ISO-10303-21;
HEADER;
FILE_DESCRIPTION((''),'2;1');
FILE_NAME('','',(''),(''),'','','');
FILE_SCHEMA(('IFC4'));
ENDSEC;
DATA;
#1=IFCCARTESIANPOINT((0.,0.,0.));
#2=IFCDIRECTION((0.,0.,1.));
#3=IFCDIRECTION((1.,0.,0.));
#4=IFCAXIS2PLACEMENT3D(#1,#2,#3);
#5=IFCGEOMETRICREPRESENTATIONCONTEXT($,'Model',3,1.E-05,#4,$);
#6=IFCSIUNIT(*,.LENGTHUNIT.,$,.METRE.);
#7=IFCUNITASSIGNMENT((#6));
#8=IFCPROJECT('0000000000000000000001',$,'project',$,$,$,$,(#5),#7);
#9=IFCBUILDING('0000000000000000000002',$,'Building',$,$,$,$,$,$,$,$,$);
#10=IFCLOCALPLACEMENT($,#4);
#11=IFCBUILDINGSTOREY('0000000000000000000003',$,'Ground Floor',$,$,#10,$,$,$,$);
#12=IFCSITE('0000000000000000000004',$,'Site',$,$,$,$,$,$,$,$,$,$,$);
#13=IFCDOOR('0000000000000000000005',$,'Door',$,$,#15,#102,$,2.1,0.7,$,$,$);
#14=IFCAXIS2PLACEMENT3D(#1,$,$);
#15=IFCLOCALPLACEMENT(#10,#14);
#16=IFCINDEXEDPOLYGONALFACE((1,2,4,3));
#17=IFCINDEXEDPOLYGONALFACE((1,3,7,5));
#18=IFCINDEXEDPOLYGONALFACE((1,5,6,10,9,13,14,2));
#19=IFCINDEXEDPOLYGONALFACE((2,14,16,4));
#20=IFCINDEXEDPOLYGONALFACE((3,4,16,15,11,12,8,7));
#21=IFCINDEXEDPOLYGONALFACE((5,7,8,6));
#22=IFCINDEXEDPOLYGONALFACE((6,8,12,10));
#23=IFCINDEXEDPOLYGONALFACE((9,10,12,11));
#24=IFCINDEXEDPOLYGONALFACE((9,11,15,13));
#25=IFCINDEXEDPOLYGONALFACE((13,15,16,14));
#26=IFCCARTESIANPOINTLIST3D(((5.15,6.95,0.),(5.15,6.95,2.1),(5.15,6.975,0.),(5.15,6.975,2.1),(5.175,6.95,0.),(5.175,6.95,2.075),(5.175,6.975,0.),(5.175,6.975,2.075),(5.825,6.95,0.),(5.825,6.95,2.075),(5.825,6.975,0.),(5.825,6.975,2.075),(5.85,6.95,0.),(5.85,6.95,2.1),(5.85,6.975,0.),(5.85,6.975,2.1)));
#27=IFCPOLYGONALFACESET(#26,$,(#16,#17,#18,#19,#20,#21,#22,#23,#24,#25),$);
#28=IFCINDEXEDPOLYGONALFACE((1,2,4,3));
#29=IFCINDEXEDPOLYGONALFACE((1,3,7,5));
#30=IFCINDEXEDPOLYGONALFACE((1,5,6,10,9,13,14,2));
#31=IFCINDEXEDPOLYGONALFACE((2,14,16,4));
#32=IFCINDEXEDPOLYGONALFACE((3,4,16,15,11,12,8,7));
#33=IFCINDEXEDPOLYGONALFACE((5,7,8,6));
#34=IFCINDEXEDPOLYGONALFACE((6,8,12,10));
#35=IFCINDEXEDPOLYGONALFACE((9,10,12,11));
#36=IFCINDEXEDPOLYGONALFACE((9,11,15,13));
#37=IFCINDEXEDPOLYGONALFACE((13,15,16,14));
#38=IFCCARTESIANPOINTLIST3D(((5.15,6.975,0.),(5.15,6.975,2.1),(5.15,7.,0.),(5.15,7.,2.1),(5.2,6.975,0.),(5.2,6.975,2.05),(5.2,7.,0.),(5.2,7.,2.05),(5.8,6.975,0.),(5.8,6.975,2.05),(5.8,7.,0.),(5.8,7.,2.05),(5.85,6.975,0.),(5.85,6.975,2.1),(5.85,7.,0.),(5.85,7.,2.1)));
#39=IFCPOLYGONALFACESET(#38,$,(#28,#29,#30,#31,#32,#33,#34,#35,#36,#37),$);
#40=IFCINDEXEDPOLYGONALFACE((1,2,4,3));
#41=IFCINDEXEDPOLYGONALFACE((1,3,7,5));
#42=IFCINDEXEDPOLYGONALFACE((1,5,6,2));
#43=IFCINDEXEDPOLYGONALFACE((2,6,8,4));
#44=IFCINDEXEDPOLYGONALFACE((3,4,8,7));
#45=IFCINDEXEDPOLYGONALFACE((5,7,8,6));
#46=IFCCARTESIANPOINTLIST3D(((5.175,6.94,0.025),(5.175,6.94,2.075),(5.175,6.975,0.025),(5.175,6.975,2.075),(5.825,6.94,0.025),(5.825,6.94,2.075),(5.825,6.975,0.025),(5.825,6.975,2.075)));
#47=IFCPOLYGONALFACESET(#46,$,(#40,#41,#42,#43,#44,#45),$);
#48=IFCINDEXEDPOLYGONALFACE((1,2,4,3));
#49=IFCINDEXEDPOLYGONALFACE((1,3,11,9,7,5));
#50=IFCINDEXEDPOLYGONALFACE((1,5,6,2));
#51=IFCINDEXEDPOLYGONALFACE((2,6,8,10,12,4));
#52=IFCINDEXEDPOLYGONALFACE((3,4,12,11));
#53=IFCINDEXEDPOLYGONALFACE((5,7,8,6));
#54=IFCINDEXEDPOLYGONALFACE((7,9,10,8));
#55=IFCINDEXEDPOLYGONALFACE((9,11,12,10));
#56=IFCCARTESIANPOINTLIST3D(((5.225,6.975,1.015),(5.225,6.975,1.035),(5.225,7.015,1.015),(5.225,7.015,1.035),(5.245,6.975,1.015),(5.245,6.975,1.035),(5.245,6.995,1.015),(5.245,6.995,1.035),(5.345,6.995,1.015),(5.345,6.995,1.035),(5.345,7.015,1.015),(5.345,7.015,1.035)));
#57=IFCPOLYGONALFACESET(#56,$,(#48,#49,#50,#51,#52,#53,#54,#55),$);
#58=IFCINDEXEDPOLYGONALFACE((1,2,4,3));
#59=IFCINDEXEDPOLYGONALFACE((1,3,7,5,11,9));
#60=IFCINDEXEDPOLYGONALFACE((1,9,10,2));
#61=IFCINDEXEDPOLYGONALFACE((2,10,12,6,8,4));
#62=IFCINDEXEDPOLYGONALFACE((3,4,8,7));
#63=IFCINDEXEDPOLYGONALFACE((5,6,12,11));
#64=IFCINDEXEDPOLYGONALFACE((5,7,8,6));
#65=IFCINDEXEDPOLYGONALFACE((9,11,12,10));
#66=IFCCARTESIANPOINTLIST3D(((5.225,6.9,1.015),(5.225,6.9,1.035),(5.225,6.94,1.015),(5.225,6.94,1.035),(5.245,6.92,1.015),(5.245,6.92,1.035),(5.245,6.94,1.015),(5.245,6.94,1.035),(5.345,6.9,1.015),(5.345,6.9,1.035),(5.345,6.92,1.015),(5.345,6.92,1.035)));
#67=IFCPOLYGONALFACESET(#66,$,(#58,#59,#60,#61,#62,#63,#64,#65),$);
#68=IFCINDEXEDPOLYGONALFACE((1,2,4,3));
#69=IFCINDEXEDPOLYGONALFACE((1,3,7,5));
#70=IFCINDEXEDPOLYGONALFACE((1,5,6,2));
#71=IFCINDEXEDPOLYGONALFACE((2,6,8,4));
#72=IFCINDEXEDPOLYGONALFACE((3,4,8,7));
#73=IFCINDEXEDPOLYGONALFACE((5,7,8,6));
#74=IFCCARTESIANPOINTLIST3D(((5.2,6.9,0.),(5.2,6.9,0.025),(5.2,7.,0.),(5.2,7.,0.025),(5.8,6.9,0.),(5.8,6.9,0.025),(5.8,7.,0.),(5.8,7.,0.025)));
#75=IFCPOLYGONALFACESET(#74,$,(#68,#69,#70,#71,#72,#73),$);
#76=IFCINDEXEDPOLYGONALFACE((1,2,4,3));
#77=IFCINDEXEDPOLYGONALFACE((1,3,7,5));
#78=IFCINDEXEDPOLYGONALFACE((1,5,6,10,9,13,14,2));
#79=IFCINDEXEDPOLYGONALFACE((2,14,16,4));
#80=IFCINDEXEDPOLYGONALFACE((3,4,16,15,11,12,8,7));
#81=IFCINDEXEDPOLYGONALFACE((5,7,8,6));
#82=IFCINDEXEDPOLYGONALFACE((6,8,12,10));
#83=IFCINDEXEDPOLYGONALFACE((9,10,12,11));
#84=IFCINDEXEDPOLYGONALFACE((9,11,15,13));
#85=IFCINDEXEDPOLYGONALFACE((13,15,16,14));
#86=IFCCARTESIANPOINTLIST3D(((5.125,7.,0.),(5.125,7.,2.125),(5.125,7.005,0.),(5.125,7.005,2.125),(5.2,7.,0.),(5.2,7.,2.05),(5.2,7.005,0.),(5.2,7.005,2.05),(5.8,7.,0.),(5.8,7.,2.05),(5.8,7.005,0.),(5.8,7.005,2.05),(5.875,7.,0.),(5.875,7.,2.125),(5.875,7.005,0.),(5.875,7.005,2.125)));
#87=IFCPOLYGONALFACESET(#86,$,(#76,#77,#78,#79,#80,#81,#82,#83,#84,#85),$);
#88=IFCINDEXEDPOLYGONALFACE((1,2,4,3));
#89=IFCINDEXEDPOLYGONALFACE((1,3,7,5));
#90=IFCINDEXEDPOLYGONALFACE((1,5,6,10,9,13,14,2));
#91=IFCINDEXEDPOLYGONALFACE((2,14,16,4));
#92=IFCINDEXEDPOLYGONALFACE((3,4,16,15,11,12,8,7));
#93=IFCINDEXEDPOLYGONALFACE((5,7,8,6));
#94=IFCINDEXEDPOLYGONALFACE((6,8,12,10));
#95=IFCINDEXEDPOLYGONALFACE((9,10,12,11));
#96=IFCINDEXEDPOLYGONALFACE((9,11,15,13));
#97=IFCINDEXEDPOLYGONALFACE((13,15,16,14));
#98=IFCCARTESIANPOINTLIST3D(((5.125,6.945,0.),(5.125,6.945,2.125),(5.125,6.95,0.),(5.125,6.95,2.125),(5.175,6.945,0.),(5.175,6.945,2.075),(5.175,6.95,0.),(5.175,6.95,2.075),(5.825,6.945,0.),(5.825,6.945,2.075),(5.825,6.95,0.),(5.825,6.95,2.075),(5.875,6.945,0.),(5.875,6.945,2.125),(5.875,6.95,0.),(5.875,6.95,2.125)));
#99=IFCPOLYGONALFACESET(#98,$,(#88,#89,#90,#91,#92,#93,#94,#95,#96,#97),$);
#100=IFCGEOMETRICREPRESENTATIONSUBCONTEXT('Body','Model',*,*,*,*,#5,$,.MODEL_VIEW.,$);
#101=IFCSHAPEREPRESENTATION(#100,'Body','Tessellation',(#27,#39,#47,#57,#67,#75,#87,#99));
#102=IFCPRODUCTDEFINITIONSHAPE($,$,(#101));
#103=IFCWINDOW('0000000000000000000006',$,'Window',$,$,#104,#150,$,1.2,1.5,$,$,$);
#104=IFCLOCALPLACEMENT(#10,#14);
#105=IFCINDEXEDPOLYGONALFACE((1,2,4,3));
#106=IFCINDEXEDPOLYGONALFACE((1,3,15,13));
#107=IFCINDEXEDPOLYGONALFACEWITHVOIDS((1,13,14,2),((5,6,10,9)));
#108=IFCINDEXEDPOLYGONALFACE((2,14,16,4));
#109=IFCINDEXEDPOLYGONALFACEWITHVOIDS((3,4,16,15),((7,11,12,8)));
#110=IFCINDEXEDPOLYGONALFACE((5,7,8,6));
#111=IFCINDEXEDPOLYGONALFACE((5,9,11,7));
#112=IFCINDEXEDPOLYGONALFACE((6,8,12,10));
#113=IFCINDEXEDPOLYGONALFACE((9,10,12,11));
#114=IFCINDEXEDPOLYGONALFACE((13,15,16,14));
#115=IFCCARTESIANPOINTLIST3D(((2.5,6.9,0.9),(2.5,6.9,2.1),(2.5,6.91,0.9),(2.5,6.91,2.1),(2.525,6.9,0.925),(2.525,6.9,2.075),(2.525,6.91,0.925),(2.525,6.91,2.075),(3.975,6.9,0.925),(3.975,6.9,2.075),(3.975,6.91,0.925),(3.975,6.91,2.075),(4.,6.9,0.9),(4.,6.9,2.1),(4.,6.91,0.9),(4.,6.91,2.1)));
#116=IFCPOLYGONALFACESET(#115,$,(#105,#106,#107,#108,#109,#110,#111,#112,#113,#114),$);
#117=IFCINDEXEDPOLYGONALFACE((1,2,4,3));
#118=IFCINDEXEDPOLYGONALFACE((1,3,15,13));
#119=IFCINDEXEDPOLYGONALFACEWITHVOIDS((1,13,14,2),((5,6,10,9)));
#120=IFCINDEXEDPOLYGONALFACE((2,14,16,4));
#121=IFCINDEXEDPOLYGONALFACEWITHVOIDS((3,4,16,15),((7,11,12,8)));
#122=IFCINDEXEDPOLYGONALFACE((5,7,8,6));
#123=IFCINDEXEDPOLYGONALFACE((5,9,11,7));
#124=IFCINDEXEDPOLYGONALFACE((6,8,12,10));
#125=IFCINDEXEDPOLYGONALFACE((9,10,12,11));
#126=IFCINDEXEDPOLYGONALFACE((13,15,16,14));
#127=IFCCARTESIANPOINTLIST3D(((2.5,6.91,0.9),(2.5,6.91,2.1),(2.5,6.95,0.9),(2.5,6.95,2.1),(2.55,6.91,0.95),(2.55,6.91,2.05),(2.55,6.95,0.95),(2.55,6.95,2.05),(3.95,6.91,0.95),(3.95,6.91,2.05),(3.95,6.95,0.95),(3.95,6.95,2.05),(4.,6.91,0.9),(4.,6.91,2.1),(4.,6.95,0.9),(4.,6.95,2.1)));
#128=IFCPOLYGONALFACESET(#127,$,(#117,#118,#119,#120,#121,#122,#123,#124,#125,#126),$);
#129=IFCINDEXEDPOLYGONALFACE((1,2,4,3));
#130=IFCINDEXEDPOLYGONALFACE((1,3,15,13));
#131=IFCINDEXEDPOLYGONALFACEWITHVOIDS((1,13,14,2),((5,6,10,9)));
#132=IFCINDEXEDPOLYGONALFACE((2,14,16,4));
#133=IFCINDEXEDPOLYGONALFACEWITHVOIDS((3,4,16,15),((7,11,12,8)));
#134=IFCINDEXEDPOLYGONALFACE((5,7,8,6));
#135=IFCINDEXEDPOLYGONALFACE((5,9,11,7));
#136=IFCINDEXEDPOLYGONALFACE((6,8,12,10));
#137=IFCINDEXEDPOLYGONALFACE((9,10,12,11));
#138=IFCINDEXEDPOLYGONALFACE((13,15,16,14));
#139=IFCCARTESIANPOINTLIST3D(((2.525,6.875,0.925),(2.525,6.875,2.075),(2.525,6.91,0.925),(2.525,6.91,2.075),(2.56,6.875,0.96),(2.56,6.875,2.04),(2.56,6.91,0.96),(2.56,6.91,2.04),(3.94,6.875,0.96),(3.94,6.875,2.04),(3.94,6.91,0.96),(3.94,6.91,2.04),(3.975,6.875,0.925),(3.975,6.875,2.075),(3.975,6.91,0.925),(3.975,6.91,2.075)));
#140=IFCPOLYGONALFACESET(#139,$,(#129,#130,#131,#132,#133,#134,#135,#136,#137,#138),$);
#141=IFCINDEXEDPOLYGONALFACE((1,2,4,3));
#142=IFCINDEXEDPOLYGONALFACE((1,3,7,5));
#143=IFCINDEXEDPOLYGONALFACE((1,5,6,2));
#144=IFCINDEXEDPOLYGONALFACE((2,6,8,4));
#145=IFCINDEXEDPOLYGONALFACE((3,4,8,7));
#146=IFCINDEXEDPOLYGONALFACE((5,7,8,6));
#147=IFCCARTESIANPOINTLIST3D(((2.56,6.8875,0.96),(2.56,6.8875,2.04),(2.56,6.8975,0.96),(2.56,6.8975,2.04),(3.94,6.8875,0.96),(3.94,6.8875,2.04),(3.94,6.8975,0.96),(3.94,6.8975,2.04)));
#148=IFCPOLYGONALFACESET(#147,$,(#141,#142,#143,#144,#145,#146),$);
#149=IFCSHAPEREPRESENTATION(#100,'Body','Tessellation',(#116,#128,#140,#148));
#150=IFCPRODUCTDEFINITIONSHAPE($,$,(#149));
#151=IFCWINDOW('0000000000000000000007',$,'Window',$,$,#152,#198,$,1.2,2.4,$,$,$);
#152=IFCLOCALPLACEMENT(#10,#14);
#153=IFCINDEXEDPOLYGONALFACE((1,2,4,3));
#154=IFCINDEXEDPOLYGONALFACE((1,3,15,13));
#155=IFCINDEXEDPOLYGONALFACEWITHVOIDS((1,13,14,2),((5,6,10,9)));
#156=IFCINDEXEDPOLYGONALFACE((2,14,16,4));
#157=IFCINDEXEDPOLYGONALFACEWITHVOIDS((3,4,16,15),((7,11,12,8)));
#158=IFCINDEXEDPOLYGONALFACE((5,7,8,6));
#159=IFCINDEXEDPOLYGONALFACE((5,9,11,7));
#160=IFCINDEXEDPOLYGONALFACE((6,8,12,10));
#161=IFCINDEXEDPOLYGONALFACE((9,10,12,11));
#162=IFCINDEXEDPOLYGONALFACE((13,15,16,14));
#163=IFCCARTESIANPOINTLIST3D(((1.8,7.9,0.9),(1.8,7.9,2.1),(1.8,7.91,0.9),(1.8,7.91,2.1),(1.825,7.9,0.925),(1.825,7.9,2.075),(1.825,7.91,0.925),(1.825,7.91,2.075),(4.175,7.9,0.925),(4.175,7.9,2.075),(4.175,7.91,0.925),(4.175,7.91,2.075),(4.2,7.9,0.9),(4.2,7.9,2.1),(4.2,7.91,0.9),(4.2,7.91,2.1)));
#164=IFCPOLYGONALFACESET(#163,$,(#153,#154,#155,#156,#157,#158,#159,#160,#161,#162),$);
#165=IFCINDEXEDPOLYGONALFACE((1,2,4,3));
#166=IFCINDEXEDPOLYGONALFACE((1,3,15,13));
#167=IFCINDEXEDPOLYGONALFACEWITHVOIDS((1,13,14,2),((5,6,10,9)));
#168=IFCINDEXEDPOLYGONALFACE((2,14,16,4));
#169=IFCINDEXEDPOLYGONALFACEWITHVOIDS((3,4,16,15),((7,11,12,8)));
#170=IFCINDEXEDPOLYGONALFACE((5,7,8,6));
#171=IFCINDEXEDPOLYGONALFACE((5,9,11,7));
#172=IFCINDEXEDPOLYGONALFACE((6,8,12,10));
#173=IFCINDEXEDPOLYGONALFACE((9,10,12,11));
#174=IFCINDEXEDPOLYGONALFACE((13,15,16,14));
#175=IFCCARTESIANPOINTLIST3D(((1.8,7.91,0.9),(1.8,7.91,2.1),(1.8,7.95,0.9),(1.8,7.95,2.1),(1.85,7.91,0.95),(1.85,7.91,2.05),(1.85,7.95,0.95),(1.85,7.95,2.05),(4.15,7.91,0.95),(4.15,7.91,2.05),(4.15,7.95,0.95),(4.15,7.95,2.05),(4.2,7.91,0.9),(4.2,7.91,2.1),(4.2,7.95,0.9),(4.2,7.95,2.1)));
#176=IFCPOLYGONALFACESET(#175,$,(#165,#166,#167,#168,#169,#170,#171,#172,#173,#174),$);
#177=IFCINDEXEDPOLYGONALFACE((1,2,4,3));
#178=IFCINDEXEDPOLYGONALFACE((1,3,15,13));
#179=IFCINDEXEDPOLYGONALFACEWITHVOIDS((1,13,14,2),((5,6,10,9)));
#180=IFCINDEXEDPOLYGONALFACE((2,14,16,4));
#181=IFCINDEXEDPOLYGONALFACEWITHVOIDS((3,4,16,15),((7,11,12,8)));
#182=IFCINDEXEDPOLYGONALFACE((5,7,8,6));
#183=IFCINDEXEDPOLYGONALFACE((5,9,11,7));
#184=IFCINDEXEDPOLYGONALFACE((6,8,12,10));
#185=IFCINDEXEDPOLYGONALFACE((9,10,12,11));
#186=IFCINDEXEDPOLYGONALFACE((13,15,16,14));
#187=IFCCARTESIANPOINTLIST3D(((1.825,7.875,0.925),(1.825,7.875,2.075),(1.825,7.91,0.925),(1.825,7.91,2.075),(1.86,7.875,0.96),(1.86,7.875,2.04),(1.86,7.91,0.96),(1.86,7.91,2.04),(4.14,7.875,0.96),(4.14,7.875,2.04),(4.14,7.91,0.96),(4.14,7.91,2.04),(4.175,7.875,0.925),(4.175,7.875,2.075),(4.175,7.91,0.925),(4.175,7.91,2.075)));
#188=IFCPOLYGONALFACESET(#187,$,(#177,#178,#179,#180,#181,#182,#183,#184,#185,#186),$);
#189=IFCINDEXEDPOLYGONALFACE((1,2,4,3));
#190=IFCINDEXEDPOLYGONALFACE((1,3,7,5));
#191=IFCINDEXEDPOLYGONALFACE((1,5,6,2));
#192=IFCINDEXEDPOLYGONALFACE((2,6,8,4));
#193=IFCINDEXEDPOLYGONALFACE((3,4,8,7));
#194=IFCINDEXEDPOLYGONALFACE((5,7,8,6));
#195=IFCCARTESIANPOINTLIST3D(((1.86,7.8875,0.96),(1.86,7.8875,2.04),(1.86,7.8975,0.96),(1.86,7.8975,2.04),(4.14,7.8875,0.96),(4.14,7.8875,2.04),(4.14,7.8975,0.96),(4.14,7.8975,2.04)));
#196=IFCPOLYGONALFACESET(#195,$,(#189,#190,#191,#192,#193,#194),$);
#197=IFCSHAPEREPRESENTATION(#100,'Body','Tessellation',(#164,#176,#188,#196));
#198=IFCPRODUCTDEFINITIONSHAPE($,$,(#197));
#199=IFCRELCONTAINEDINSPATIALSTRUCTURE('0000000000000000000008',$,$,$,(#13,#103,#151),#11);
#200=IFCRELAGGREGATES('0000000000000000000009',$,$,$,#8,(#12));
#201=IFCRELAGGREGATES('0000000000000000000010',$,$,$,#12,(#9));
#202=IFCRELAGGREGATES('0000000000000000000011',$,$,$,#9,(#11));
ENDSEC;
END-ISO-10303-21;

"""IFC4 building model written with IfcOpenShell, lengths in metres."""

from ifc_helpers import new_model, si_unit, frame, origin_with_axes, place, context, subcontext, project, spatial, line, indexed_curve, outline, extrude, element, save


model = new_model("IFC4")

# Units and contexts
model_context = context("Model", 3, precision=1e-05, world=origin_with_axes())
body_context = subcontext(model_context, "Body", "Model", "MODEL_VIEW")
ifc_project = project(units=[si_unit("LENGTHUNIT", "METRE")], contexts=[model_context])

# Site, building, storey
site = spatial("IfcSite", under=ifc_project, Name="Site")
building = spatial("IfcBuilding", under=site, Name="Building")
storey_placement = place(None, origin_with_axes())
storey = spatial("IfcBuildingStorey", under=building, at=storey_placement, Name="Ground Floor")

# Door
door_1_placement = place(storey_placement, frame((5.85, 7.0, 0.0), z_axis=(0.0, 0.0, 1.0), x_axis=(-1.0, 0.0, 0.0)))
element("IfcDoor", 1, at=door_1_placement, inside=storey, Name="Door", OverallHeight=2.1, OverallWidth=0.7, context=body_context, shape_type="SweptSolid", body=[
    extrude(outline(indexed_curve([(0.0, 0.0), (0.0, 2.1), (0.7, 2.1), (0.7, 0.0), (0.675, 0.0), (0.675, 2.075), (0.025, 2.075), (0.025, 0.0)], segments=[line(1, 2, 3, 4, 5, 6, 7, 8, 1)])), frame((0.0, 0.025, 0.0), z_axis=(0.0, -1.0, 0.0), x_axis=(1.0, 0.0, 0.0)), (0.0, 0.0, -1.0), 0.025),
    extrude(outline(indexed_curve([(0.0, 0.0), (0.0, 2.1), (0.7, 2.1), (0.7, 0.0), (0.65, 0.0), (0.65, 2.05), (0.05, 2.05), (0.05, 0.0)], segments=[line(1, 2, 3, 4, 5, 6, 7, 8, 1)])), frame((0.0, 0.0, 0.0), z_axis=(0.0, -1.0, 0.0), x_axis=(1.0, 0.0, 0.0)), (0.0, 0.0, -1.0), 0.025),
    extrude(outline(indexed_curve([(0.0, 0.0), (0.65, 0.0), (0.65, 0.035), (0.0, 0.035)], segments=[line(1, 2, 3, 4, 1)])), frame((0.025, 0.025, 0.025), z_axis=(0.0, 0.0, 1.0), x_axis=(1.0, 0.0, 0.0)), (0.0, 0.0, 1.0), 2.05),
    extrude(outline(indexed_curve([(0.0, 0.0), (0.0, -0.04), (-0.12, -0.04), (-0.12, -0.02), (-0.02, -0.02), (-0.02, 0.0)], segments=[line(1, 2, 3, 4, 5, 6, 1)])), frame((0.625, 0.025, 1.015), z_axis=(0.0, 0.0, 1.0), x_axis=(1.0, 0.0, 0.0)), (0.0, 0.0, 1.0), 0.02),
    extrude(outline(indexed_curve([(0.0, 0.0), (0.0, 0.04), (-0.12, 0.04), (-0.12, 0.02), (-0.02, 0.02), (-0.02, 0.0)], segments=[line(1, 2, 3, 4, 5, 6, 1)])), frame((0.625, 0.06, 1.015), z_axis=(0.0, 0.0, 1.0), x_axis=(1.0, 0.0, 0.0)), (0.0, 0.0, 1.0), 0.02),
    extrude(outline(indexed_curve([(0.0, 0.0), (0.6, 0.0), (0.6, 0.1), (0.0, 0.1)], segments=[line(1, 2, 3, 4, 1)])), frame((0.05, 0.0, 0.0), z_axis=(0.0, 0.0, 1.0), x_axis=(1.0, 0.0, 0.0)), (0.0, 0.0, 1.0), 0.025),
    extrude(outline(indexed_curve([(0.0, 0.0), (0.0, 2.125), (0.75, 2.125), (0.75, 0.0), (0.675, 0.0), (0.675, 2.05), (0.075, 2.05), (0.075, 0.0)], segments=[line(1, 2, 3, 4, 5, 6, 7, 8, 1)])), frame((-0.025, -0.005, 0.0), z_axis=(0.0, -1.0, 0.0), x_axis=(1.0, 0.0, 0.0)), (0.0, 0.0, -1.0), 0.005),
    extrude(outline(indexed_curve([(0.0, 0.0), (0.0, 2.125), (0.75, 2.125), (0.75, 0.0), (0.7, 0.0), (0.7, 2.075), (0.05, 2.075), (0.05, 0.0)], segments=[line(1, 2, 3, 4, 5, 6, 7, 8, 1)])), frame((-0.025, 0.05, 0.0), z_axis=(0.0, -1.0, 0.0), x_axis=(1.0, 0.0, 0.0)), (0.0, 0.0, -1.0), 0.005),
])

# Windows
window_1_placement = place(storey_placement, frame((4.0, 7.0, 0.9), z_axis=(0.0, 0.0, 1.0), x_axis=(-1.0, 0.0, 0.0)))
element("IfcWindow", 2, at=window_1_placement, inside=storey, Name="Window", OverallHeight=1.2, OverallWidth=1.5, context=body_context, shape_type="SweptSolid", body=[
    extrude(outline(indexed_curve([(0.0, 0.0), (1.5, 0.0), (1.5, 1.2), (0.0, 1.2)], segments=[line(1, 2, 3, 4, 1)]), holes=[indexed_curve([(0.025, 0.025), (1.475, 0.025), (1.475, 1.175), (0.025, 1.175)], segments=[line(1, 2, 3, 4, 1)])]), frame((0.0, 0.09, 0.0), z_axis=(0.0, -1.0, 0.0), x_axis=(1.0, 0.0, 0.0)), (0.0, 0.0, -1.0), 0.01),
    extrude(outline(indexed_curve([(0.0, 0.0), (1.5, 0.0), (1.5, 1.2), (0.0, 1.2)], segments=[line(1, 2, 3, 4, 1)]), holes=[indexed_curve([(0.05, 0.05), (1.45, 0.05), (1.45, 1.15), (0.05, 1.15)], segments=[line(1, 2, 3, 4, 1)])]), frame((0.0, 0.05, 0.0), z_axis=(0.0, -1.0, 0.0), x_axis=(1.0, 0.0, 0.0)), (0.0, 0.0, -1.0), 0.04),
    extrude(outline(indexed_curve([(0.0, 0.0), (1.45, 0.0), (1.45, 1.15), (0.0, 1.15)], segments=[line(1, 2, 3, 4, 1)]), holes=[indexed_curve([(0.035, 0.035), (1.415, 0.035), (1.415, 1.115), (0.035, 1.115)], segments=[line(1, 2, 3, 4, 1)])]), frame((0.025, 0.09, 0.025), z_axis=(0.0, -1.0, 0.0), x_axis=(1.0, 0.0, 0.0)), (0.0, 0.0, -1.0), 0.035),
    extrude(outline(indexed_curve([(0.035, 0.035), (1.415, 0.035), (1.415, 1.115), (0.035, 1.115)], segments=[line(1, 2, 3, 4, 1)])), frame((0.025, 0.1025, 0.025), z_axis=(0.0, -1.0, 0.0), x_axis=(1.0, 0.0, 0.0)), (0.0, 0.0, -1.0), 0.01),
])
window_2_placement = place(storey_placement, frame((4.2, 8.0, 0.9), z_axis=(0.0, 0.0, 1.0), x_axis=(-1.0, 0.0, 0.0)))
element("IfcWindow", 3, at=window_2_placement, inside=storey, Name="Window", OverallHeight=1.2, OverallWidth=2.4, context=body_context, shape_type="SweptSolid", body=[
    extrude(outline(indexed_curve([(0.0, 0.0), (2.4, 0.0), (2.4, 1.2), (0.0, 1.2)], segments=[line(1, 2, 3, 4, 1)]), holes=[indexed_curve([(0.025, 0.025), (2.375, 0.025), (2.375, 1.175), (0.025, 1.175)], segments=[line(1, 2, 3, 4, 1)])]), frame((0.0, 0.09, 0.0), z_axis=(0.0, -1.0, 0.0), x_axis=(1.0, 0.0, 0.0)), (0.0, 0.0, -1.0), 0.01),
    extrude(outline(indexed_curve([(0.0, 0.0), (2.4, 0.0), (2.4, 1.2), (0.0, 1.2)], segments=[line(1, 2, 3, 4, 1)]), holes=[indexed_curve([(0.05, 0.05), (2.35, 0.05), (2.35, 1.15), (0.05, 1.15)], segments=[line(1, 2, 3, 4, 1)])]), frame((0.0, 0.05, 0.0), z_axis=(0.0, -1.0, 0.0), x_axis=(1.0, 0.0, 0.0)), (0.0, 0.0, -1.0), 0.04),
    extrude(outline(indexed_curve([(0.0, 0.0), (2.35, 0.0), (2.35, 1.15), (0.0, 1.15)], segments=[line(1, 2, 3, 4, 1)]), holes=[indexed_curve([(0.035, 0.035), (2.315, 0.035), (2.315, 1.115), (0.035, 1.115)], segments=[line(1, 2, 3, 4, 1)])]), frame((0.025, 0.09, 0.025), z_axis=(0.0, -1.0, 0.0), x_axis=(1.0, 0.0, 0.0)), (0.0, 0.0, -1.0), 0.035),
    extrude(outline(indexed_curve([(0.035, 0.035), (2.315, 0.035), (2.315, 1.115), (0.035, 1.115)], segments=[line(1, 2, 3, 4, 1)])), frame((0.025, 0.1025, 0.025), z_axis=(0.0, -1.0, 0.0), x_axis=(1.0, 0.0, 0.0)), (0.0, 0.0, -1.0), 0.01),
])

save(model, "model.ifc")
